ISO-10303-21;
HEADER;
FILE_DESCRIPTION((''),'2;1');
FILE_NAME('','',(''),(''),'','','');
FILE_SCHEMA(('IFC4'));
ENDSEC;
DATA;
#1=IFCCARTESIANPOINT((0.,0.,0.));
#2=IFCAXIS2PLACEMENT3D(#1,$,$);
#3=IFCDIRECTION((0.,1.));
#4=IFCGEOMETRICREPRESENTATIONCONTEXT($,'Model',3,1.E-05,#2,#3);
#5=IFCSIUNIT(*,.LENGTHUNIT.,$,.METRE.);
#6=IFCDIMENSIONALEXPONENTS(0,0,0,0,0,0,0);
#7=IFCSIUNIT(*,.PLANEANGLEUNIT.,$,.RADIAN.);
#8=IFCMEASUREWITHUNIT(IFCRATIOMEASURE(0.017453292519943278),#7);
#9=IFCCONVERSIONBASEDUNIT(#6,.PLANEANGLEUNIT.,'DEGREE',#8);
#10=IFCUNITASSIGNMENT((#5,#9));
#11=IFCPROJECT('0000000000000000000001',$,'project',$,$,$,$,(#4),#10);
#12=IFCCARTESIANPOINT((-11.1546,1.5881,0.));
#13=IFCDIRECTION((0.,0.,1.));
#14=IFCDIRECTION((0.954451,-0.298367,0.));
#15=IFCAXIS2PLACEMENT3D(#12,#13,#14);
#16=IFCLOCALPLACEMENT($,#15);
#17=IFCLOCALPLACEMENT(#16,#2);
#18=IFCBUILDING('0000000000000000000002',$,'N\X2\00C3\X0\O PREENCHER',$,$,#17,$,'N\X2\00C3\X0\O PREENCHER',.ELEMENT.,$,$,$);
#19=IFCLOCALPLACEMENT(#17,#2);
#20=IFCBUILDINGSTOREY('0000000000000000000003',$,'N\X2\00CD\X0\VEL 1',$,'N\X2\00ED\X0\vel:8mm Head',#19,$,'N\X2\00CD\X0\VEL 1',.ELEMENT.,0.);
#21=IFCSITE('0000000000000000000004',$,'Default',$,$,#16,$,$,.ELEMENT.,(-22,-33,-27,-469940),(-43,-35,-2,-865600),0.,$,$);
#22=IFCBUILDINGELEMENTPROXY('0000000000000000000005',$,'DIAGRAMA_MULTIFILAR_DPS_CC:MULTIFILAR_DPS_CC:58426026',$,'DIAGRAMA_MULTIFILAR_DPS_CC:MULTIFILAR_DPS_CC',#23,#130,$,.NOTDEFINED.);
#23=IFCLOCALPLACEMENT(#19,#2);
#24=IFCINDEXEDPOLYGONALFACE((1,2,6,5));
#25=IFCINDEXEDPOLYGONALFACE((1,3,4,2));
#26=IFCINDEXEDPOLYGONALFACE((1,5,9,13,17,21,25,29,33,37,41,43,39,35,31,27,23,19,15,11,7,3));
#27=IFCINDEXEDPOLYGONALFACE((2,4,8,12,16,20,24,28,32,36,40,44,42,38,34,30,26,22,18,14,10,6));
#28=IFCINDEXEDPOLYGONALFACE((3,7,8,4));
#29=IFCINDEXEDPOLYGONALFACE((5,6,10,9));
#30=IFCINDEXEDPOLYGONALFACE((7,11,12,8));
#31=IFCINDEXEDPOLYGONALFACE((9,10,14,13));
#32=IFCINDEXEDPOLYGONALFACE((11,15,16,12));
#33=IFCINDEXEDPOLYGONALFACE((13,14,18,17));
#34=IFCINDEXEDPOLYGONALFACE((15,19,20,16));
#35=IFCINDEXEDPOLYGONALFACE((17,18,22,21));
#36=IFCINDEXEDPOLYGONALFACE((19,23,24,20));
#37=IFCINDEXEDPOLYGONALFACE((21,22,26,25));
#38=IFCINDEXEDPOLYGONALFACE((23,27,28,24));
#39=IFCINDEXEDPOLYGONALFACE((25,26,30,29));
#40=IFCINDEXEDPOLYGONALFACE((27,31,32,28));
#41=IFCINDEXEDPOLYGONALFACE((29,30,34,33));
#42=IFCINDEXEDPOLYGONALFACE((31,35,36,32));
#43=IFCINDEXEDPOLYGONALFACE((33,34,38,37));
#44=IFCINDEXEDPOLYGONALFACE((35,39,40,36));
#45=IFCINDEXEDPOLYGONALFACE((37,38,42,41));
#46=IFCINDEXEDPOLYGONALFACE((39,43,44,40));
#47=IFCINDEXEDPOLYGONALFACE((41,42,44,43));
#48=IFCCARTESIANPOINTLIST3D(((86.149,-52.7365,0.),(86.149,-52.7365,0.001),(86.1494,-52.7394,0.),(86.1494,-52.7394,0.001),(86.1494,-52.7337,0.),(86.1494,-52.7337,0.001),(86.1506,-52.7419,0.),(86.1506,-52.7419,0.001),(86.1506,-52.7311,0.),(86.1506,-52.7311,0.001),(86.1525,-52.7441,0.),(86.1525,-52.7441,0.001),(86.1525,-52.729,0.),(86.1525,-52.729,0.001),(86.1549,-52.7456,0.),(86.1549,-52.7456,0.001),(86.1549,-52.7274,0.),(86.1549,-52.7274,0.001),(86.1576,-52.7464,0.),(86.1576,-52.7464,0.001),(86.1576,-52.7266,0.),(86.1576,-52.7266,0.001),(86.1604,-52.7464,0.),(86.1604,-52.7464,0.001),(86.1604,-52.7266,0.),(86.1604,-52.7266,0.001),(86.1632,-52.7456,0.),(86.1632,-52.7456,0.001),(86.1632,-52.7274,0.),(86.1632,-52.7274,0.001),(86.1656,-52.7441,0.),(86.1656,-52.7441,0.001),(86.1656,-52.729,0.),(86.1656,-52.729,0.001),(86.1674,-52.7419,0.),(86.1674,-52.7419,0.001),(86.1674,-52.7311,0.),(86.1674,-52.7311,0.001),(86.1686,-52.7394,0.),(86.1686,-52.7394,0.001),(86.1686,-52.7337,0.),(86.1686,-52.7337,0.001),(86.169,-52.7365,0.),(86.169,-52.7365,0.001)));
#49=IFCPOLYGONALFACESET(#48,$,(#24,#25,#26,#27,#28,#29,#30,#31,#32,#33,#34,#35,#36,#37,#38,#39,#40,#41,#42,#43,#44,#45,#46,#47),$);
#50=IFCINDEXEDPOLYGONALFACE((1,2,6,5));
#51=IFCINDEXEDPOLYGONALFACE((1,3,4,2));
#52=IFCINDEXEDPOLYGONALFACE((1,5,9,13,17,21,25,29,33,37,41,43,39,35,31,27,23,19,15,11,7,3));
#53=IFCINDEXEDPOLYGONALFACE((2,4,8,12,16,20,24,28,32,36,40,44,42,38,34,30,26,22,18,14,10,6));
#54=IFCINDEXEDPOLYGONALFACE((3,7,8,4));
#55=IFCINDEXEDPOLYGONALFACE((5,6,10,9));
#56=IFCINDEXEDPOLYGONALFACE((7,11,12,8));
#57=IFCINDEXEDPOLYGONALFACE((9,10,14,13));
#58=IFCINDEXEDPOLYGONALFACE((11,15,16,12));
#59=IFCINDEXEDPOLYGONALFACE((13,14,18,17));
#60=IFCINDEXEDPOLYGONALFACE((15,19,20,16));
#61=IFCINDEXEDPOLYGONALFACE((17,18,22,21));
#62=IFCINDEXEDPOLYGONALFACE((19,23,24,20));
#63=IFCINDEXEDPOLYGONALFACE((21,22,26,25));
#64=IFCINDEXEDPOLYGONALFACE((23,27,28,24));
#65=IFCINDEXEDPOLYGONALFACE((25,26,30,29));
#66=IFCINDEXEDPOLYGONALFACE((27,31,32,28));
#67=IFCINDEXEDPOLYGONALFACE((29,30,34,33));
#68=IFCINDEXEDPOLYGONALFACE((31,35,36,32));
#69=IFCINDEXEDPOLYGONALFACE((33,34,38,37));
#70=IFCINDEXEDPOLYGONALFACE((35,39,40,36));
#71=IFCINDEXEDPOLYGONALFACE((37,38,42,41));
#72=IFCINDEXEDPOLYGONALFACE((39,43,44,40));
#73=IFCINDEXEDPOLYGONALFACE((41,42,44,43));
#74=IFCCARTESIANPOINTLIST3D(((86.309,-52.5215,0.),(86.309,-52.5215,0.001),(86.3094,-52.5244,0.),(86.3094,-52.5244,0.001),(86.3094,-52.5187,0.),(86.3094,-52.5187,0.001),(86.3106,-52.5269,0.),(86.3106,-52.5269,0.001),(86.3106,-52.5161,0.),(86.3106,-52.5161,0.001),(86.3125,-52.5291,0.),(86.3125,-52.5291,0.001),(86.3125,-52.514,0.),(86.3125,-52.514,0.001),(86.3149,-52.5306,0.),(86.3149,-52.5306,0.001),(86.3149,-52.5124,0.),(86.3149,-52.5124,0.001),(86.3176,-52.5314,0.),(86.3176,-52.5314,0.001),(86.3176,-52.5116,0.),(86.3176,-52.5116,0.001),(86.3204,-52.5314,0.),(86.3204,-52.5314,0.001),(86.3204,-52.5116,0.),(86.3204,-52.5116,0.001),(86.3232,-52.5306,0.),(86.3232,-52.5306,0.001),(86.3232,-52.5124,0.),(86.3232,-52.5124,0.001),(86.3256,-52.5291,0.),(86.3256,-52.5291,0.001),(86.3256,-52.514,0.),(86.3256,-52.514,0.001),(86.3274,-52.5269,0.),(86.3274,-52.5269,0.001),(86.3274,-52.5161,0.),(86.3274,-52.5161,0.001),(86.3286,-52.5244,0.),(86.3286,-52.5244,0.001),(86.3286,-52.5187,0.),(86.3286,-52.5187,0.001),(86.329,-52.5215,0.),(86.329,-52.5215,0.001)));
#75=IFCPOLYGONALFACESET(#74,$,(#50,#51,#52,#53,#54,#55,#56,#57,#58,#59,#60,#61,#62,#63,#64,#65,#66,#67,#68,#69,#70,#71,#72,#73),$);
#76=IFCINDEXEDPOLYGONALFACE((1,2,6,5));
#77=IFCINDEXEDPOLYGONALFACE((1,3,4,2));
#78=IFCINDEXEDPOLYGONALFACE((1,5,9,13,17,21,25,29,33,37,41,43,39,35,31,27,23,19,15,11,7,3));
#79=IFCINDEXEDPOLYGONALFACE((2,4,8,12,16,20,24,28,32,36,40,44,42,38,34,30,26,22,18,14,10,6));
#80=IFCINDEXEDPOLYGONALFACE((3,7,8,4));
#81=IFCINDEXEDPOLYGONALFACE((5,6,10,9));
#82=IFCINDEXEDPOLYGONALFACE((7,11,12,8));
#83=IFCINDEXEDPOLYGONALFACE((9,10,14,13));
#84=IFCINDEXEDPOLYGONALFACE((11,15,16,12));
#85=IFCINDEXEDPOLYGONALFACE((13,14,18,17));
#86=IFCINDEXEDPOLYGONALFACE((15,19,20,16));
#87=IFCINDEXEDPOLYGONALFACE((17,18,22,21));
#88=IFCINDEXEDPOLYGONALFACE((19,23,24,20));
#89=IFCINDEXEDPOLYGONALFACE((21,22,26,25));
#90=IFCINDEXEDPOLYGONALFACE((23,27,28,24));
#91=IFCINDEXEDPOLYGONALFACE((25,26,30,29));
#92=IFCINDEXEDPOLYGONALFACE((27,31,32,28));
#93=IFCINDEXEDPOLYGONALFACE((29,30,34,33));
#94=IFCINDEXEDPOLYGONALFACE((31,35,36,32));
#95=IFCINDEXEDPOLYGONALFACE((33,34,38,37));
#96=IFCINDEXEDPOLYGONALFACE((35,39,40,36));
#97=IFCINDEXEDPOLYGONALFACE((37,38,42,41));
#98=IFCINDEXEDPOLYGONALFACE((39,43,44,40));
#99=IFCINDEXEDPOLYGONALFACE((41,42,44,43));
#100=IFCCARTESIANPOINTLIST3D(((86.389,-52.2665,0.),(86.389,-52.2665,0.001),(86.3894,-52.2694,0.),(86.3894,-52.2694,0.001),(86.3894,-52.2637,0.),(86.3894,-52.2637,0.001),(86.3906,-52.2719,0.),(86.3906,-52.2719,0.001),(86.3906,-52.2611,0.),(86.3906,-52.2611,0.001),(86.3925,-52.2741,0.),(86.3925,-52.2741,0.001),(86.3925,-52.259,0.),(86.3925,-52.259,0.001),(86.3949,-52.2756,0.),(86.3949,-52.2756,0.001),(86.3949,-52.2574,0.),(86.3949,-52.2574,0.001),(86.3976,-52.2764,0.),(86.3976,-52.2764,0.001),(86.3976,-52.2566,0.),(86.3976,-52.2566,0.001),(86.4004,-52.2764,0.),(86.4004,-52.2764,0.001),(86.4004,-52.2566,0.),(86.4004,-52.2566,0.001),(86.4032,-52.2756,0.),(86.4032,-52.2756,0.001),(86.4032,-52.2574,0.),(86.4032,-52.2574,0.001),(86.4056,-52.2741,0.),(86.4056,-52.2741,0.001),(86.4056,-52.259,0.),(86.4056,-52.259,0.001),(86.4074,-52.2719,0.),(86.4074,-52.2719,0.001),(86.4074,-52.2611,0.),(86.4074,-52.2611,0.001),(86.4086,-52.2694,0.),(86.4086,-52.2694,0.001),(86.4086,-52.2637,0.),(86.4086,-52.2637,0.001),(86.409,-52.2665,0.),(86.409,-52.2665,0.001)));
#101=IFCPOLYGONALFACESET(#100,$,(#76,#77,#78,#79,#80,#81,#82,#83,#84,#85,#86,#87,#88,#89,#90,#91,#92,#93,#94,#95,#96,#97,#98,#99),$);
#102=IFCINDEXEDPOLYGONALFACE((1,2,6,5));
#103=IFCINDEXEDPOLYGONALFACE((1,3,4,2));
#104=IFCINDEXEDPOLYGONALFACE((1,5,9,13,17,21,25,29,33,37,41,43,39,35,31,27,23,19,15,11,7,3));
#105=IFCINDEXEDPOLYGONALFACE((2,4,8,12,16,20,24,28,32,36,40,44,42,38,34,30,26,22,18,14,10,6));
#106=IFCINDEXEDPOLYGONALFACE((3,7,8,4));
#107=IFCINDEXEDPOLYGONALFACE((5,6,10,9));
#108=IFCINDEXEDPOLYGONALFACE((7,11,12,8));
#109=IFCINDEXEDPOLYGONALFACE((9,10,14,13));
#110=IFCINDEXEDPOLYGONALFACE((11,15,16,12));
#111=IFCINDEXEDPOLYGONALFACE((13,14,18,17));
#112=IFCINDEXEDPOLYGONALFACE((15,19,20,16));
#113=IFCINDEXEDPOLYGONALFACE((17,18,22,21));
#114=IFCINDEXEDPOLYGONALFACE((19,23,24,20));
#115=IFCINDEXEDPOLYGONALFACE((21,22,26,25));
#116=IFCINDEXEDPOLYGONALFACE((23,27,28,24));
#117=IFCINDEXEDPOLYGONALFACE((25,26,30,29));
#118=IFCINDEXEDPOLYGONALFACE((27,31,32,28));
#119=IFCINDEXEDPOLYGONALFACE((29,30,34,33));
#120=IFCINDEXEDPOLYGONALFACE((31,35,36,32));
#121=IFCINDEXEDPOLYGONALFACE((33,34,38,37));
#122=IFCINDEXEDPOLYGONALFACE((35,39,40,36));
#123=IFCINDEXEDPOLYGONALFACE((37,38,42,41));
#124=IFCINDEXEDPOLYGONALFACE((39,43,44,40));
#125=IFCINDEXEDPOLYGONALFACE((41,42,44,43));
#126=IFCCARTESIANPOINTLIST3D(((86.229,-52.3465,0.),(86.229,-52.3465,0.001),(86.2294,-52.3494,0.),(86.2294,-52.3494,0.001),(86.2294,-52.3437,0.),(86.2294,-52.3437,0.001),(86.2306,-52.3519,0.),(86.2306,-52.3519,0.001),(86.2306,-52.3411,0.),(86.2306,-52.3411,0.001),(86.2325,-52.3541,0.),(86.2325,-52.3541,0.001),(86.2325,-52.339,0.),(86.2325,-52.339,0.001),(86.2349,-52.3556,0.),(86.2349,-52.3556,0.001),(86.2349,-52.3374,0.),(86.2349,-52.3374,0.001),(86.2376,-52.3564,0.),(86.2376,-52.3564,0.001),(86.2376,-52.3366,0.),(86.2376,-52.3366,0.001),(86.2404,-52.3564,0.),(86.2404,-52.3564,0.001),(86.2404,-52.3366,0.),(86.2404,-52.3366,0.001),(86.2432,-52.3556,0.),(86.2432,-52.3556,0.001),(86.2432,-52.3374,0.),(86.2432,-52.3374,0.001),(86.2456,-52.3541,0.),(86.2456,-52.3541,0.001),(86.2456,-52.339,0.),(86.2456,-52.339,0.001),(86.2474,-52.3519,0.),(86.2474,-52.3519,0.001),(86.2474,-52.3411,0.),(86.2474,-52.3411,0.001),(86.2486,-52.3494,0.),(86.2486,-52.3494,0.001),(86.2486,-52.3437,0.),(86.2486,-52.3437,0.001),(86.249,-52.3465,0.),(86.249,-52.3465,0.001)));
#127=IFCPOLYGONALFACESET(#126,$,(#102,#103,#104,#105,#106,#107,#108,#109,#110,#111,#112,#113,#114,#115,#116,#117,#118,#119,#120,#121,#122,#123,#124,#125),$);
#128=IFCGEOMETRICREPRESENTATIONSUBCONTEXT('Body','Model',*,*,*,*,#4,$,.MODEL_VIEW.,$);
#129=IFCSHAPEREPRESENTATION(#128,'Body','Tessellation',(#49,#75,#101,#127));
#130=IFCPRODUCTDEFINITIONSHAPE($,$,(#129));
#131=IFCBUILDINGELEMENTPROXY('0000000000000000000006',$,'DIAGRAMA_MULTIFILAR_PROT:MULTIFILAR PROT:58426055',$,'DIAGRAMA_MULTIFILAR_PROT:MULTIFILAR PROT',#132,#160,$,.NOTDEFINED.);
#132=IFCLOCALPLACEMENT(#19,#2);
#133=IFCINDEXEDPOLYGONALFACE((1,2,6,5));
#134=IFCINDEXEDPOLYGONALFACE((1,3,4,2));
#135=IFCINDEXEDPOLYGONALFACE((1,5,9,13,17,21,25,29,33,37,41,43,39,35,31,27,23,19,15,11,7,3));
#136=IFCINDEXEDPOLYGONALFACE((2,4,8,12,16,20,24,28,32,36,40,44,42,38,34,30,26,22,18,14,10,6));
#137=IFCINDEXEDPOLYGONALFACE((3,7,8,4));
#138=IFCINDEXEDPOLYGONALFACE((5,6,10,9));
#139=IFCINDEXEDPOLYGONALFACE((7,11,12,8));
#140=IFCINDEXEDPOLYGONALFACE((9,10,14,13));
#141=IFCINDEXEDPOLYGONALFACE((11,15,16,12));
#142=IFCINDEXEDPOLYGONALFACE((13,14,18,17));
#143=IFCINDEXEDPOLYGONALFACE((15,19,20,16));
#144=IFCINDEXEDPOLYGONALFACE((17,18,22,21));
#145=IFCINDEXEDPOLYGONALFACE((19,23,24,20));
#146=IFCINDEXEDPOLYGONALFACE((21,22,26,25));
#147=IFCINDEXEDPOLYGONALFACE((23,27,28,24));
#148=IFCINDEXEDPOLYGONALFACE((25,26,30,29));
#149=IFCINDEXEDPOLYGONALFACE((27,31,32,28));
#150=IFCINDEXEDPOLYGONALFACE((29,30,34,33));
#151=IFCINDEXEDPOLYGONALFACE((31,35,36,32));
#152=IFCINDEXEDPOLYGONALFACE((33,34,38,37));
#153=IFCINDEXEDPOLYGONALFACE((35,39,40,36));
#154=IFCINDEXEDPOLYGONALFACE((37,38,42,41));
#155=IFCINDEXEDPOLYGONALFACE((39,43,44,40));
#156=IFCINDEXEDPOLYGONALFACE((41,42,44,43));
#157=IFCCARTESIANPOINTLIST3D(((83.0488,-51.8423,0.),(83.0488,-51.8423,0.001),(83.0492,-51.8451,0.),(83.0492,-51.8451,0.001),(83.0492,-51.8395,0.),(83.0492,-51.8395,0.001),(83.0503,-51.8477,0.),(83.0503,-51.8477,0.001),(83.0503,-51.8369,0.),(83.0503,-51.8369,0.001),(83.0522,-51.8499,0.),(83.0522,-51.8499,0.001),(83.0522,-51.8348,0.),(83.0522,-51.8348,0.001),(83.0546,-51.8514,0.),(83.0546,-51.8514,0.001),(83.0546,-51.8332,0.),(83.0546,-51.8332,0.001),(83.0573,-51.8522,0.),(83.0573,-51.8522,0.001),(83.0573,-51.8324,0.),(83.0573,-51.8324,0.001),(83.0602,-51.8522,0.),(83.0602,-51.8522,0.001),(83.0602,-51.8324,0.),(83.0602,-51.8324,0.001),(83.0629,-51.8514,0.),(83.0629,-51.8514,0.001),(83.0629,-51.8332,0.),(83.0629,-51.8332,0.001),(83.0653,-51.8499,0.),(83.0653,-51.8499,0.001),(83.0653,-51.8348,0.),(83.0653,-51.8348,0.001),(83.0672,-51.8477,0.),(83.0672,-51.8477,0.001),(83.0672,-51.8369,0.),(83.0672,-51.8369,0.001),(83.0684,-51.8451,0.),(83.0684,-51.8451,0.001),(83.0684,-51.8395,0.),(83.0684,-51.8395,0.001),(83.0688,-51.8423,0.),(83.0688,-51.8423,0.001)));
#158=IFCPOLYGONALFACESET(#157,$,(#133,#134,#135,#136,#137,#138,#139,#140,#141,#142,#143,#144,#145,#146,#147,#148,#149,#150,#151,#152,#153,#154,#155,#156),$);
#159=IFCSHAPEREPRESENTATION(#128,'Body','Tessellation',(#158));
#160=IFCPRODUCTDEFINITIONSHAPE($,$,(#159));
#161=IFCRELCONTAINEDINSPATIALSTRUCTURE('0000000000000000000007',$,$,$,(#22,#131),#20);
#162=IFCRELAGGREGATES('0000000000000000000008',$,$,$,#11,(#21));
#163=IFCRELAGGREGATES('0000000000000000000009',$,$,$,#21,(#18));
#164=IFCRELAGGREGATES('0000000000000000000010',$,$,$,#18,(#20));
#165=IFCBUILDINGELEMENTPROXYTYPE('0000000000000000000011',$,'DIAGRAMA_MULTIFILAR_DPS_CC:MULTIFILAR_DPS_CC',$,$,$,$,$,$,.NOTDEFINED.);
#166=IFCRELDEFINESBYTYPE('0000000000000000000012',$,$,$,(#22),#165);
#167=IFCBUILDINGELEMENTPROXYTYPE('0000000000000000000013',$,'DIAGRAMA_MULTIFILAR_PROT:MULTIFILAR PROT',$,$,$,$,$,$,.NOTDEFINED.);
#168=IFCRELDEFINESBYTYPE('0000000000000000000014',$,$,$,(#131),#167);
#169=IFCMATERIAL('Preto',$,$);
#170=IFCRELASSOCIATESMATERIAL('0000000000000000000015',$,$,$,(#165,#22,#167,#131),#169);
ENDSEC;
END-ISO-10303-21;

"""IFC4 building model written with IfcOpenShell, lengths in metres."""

from ifc_helpers import new_model, entity, si_unit, converted_unit, direction, frame, origin, place, context, subcontext, project, spatial, arc, indexed_curve, outline, extrude, source, transform, mapped, material, type_object, type_shapes, element, save


model = new_model("IFC4")

# Units and contexts
model_context = context("Model", 3, precision=1e-05, world=origin(), true_north=direction((0.0, 1.0)))
body_context = subcontext(model_context, "Body", "Model", "MODEL_VIEW")
ifc_project = project(units=[si_unit("LENGTHUNIT", "METRE"), converted_unit("PLANEANGLEUNIT", "DEGREE", entity("IfcRatioMeasure", 0.017453292519943278), si_unit("PLANEANGLEUNIT", "RADIAN"), dimensions=[0, 0, 0, 0, 0, 0, 0])], contexts=[model_context])

# Site, building, storey
site_placement = place(None, frame((-11.1546, 1.5881, 0.0), z_axis=(0.0, 0.0, 1.0), x_axis=(0.954451, -0.298367, 0.0)))
site = spatial("IfcSite", under=ifc_project, at=site_placement, Name="Default", CompositionType="ELEMENT", RefLatitude=(-22, -33, -27, -469940), RefLongitude=(-43, -35, -2, -865600), RefElevation=0.0)
building_placement = place(site_placement, origin())
building = spatial("IfcBuilding", under=site, at=building_placement, Name="NÃO PREENCHER", LongName="NÃO PREENCHER", CompositionType="ELEMENT")
storey_placement = place(building_placement, origin())
storey = spatial("IfcBuildingStorey", under=building, at=storey_placement, Name="NÍVEL 1", ObjectType="Nível:8mm Head", LongName="NÍVEL 1", CompositionType="ELEMENT", Elevation=0.0)

# Building element proxies
ifc_material = material(Name="Preto")
building_element_proxy_type_1 = type_object("IfcBuildingElementProxyType", Name="DIAGRAMA_MULTIFILAR_DPS_CC:MULTIFILAR_DPS_CC", PredefinedType="NOTDEFINED", material=ifc_material)
shared_shape_1 = source(origin(), body_context, "Body", "SweptSolid", [
    extrude(outline(indexed_curve([(-0.01, 0.0), (0.0, -0.01), (0.01, 0.0), (0.0, 0.01)], segments=[arc(1, 2, 3), arc(3, 4, 1)], self_intersect=False)), frame((0.0116, 0.0116, 0.0)), (0.0, 0.0, 1.0), 0.001),
    extrude(outline(indexed_curve([(-0.01, 0.0), (0.0, -0.01), (0.01, 0.0), (0.0, 0.01)], segments=[arc(1, 2, 3), arc(3, 4, 1)], self_intersect=False)), frame((0.1716, 0.2266, 0.0)), (0.0, 0.0, 1.0), 0.001),
    extrude(outline(indexed_curve([(-0.01, 0.0), (0.0, -0.01), (0.01, 0.0), (0.0, 0.01)], segments=[arc(1, 2, 3), arc(3, 4, 1)], self_intersect=False)), frame((0.2516, 0.4816, 0.0)), (0.0, 0.0, 1.0), 0.001),
    extrude(outline(indexed_curve([(-0.01, 0.0), (0.0, -0.01), (0.01, 0.0), (0.0, 0.01)], segments=[arc(1, 2, 3), arc(3, 4, 1)], self_intersect=False)), frame((0.0916, 0.4016, 0.0)), (0.0, 0.0, 1.0), 0.001),
])
type_shapes(building_element_proxy_type_1, [shared_shape_1])
for number, where, name in (
    (1, (86.1474, -52.7481, 0.0), "DIAGRAMA_MULTIFILAR_DPS_CC:MULTIFILAR_DPS_CC:58426026"),
):
    element("IfcBuildingElementProxy", number, at=place(storey_placement, frame(where)), inside=storey, type_object=building_element_proxy_type_1, material=ifc_material, Name=name, ObjectType="DIAGRAMA_MULTIFILAR_DPS_CC:MULTIFILAR_DPS_CC", PredefinedType="NOTDEFINED", context=body_context, shape_type="MappedRepresentation", body=[
        mapped(shared_shape_1, transform((0.0, 0.0, 0.0), scale=1.0)),
    ])
building_element_proxy_type_2 = type_object("IfcBuildingElementProxyType", Name="DIAGRAMA_MULTIFILAR_PROT:MULTIFILAR PROT", PredefinedType="NOTDEFINED", material=ifc_material)
shared_shape_2 = source(origin(), body_context, "Body", "SweptSolid", [
    extrude(outline(indexed_curve([(-0.01, 0.0), (0.0, -0.01), (0.01, 0.0), (0.0, 0.01)], segments=[arc(1, 2, 3), arc(3, 4, 1)], self_intersect=False)), frame((0.0116, 0.0116, 0.0)), (0.0, 0.0, 1.0), 0.001),
])
type_shapes(building_element_proxy_type_2, [shared_shape_2])
proxy_1_placement = place(storey_placement, frame((83.0472, -51.8539, 0.0)))
element("IfcBuildingElementProxy", 2, at=proxy_1_placement, inside=storey, type_object=building_element_proxy_type_2, material=ifc_material, Name="DIAGRAMA_MULTIFILAR_PROT:MULTIFILAR PROT:58426055", ObjectType="DIAGRAMA_MULTIFILAR_PROT:MULTIFILAR PROT", PredefinedType="NOTDEFINED", context=body_context, shape_type="MappedRepresentation", body=[
    mapped(shared_shape_2, transform((0.0, 0.0, 0.0), scale=1.0)),
])

save(model, "model.ifc")
